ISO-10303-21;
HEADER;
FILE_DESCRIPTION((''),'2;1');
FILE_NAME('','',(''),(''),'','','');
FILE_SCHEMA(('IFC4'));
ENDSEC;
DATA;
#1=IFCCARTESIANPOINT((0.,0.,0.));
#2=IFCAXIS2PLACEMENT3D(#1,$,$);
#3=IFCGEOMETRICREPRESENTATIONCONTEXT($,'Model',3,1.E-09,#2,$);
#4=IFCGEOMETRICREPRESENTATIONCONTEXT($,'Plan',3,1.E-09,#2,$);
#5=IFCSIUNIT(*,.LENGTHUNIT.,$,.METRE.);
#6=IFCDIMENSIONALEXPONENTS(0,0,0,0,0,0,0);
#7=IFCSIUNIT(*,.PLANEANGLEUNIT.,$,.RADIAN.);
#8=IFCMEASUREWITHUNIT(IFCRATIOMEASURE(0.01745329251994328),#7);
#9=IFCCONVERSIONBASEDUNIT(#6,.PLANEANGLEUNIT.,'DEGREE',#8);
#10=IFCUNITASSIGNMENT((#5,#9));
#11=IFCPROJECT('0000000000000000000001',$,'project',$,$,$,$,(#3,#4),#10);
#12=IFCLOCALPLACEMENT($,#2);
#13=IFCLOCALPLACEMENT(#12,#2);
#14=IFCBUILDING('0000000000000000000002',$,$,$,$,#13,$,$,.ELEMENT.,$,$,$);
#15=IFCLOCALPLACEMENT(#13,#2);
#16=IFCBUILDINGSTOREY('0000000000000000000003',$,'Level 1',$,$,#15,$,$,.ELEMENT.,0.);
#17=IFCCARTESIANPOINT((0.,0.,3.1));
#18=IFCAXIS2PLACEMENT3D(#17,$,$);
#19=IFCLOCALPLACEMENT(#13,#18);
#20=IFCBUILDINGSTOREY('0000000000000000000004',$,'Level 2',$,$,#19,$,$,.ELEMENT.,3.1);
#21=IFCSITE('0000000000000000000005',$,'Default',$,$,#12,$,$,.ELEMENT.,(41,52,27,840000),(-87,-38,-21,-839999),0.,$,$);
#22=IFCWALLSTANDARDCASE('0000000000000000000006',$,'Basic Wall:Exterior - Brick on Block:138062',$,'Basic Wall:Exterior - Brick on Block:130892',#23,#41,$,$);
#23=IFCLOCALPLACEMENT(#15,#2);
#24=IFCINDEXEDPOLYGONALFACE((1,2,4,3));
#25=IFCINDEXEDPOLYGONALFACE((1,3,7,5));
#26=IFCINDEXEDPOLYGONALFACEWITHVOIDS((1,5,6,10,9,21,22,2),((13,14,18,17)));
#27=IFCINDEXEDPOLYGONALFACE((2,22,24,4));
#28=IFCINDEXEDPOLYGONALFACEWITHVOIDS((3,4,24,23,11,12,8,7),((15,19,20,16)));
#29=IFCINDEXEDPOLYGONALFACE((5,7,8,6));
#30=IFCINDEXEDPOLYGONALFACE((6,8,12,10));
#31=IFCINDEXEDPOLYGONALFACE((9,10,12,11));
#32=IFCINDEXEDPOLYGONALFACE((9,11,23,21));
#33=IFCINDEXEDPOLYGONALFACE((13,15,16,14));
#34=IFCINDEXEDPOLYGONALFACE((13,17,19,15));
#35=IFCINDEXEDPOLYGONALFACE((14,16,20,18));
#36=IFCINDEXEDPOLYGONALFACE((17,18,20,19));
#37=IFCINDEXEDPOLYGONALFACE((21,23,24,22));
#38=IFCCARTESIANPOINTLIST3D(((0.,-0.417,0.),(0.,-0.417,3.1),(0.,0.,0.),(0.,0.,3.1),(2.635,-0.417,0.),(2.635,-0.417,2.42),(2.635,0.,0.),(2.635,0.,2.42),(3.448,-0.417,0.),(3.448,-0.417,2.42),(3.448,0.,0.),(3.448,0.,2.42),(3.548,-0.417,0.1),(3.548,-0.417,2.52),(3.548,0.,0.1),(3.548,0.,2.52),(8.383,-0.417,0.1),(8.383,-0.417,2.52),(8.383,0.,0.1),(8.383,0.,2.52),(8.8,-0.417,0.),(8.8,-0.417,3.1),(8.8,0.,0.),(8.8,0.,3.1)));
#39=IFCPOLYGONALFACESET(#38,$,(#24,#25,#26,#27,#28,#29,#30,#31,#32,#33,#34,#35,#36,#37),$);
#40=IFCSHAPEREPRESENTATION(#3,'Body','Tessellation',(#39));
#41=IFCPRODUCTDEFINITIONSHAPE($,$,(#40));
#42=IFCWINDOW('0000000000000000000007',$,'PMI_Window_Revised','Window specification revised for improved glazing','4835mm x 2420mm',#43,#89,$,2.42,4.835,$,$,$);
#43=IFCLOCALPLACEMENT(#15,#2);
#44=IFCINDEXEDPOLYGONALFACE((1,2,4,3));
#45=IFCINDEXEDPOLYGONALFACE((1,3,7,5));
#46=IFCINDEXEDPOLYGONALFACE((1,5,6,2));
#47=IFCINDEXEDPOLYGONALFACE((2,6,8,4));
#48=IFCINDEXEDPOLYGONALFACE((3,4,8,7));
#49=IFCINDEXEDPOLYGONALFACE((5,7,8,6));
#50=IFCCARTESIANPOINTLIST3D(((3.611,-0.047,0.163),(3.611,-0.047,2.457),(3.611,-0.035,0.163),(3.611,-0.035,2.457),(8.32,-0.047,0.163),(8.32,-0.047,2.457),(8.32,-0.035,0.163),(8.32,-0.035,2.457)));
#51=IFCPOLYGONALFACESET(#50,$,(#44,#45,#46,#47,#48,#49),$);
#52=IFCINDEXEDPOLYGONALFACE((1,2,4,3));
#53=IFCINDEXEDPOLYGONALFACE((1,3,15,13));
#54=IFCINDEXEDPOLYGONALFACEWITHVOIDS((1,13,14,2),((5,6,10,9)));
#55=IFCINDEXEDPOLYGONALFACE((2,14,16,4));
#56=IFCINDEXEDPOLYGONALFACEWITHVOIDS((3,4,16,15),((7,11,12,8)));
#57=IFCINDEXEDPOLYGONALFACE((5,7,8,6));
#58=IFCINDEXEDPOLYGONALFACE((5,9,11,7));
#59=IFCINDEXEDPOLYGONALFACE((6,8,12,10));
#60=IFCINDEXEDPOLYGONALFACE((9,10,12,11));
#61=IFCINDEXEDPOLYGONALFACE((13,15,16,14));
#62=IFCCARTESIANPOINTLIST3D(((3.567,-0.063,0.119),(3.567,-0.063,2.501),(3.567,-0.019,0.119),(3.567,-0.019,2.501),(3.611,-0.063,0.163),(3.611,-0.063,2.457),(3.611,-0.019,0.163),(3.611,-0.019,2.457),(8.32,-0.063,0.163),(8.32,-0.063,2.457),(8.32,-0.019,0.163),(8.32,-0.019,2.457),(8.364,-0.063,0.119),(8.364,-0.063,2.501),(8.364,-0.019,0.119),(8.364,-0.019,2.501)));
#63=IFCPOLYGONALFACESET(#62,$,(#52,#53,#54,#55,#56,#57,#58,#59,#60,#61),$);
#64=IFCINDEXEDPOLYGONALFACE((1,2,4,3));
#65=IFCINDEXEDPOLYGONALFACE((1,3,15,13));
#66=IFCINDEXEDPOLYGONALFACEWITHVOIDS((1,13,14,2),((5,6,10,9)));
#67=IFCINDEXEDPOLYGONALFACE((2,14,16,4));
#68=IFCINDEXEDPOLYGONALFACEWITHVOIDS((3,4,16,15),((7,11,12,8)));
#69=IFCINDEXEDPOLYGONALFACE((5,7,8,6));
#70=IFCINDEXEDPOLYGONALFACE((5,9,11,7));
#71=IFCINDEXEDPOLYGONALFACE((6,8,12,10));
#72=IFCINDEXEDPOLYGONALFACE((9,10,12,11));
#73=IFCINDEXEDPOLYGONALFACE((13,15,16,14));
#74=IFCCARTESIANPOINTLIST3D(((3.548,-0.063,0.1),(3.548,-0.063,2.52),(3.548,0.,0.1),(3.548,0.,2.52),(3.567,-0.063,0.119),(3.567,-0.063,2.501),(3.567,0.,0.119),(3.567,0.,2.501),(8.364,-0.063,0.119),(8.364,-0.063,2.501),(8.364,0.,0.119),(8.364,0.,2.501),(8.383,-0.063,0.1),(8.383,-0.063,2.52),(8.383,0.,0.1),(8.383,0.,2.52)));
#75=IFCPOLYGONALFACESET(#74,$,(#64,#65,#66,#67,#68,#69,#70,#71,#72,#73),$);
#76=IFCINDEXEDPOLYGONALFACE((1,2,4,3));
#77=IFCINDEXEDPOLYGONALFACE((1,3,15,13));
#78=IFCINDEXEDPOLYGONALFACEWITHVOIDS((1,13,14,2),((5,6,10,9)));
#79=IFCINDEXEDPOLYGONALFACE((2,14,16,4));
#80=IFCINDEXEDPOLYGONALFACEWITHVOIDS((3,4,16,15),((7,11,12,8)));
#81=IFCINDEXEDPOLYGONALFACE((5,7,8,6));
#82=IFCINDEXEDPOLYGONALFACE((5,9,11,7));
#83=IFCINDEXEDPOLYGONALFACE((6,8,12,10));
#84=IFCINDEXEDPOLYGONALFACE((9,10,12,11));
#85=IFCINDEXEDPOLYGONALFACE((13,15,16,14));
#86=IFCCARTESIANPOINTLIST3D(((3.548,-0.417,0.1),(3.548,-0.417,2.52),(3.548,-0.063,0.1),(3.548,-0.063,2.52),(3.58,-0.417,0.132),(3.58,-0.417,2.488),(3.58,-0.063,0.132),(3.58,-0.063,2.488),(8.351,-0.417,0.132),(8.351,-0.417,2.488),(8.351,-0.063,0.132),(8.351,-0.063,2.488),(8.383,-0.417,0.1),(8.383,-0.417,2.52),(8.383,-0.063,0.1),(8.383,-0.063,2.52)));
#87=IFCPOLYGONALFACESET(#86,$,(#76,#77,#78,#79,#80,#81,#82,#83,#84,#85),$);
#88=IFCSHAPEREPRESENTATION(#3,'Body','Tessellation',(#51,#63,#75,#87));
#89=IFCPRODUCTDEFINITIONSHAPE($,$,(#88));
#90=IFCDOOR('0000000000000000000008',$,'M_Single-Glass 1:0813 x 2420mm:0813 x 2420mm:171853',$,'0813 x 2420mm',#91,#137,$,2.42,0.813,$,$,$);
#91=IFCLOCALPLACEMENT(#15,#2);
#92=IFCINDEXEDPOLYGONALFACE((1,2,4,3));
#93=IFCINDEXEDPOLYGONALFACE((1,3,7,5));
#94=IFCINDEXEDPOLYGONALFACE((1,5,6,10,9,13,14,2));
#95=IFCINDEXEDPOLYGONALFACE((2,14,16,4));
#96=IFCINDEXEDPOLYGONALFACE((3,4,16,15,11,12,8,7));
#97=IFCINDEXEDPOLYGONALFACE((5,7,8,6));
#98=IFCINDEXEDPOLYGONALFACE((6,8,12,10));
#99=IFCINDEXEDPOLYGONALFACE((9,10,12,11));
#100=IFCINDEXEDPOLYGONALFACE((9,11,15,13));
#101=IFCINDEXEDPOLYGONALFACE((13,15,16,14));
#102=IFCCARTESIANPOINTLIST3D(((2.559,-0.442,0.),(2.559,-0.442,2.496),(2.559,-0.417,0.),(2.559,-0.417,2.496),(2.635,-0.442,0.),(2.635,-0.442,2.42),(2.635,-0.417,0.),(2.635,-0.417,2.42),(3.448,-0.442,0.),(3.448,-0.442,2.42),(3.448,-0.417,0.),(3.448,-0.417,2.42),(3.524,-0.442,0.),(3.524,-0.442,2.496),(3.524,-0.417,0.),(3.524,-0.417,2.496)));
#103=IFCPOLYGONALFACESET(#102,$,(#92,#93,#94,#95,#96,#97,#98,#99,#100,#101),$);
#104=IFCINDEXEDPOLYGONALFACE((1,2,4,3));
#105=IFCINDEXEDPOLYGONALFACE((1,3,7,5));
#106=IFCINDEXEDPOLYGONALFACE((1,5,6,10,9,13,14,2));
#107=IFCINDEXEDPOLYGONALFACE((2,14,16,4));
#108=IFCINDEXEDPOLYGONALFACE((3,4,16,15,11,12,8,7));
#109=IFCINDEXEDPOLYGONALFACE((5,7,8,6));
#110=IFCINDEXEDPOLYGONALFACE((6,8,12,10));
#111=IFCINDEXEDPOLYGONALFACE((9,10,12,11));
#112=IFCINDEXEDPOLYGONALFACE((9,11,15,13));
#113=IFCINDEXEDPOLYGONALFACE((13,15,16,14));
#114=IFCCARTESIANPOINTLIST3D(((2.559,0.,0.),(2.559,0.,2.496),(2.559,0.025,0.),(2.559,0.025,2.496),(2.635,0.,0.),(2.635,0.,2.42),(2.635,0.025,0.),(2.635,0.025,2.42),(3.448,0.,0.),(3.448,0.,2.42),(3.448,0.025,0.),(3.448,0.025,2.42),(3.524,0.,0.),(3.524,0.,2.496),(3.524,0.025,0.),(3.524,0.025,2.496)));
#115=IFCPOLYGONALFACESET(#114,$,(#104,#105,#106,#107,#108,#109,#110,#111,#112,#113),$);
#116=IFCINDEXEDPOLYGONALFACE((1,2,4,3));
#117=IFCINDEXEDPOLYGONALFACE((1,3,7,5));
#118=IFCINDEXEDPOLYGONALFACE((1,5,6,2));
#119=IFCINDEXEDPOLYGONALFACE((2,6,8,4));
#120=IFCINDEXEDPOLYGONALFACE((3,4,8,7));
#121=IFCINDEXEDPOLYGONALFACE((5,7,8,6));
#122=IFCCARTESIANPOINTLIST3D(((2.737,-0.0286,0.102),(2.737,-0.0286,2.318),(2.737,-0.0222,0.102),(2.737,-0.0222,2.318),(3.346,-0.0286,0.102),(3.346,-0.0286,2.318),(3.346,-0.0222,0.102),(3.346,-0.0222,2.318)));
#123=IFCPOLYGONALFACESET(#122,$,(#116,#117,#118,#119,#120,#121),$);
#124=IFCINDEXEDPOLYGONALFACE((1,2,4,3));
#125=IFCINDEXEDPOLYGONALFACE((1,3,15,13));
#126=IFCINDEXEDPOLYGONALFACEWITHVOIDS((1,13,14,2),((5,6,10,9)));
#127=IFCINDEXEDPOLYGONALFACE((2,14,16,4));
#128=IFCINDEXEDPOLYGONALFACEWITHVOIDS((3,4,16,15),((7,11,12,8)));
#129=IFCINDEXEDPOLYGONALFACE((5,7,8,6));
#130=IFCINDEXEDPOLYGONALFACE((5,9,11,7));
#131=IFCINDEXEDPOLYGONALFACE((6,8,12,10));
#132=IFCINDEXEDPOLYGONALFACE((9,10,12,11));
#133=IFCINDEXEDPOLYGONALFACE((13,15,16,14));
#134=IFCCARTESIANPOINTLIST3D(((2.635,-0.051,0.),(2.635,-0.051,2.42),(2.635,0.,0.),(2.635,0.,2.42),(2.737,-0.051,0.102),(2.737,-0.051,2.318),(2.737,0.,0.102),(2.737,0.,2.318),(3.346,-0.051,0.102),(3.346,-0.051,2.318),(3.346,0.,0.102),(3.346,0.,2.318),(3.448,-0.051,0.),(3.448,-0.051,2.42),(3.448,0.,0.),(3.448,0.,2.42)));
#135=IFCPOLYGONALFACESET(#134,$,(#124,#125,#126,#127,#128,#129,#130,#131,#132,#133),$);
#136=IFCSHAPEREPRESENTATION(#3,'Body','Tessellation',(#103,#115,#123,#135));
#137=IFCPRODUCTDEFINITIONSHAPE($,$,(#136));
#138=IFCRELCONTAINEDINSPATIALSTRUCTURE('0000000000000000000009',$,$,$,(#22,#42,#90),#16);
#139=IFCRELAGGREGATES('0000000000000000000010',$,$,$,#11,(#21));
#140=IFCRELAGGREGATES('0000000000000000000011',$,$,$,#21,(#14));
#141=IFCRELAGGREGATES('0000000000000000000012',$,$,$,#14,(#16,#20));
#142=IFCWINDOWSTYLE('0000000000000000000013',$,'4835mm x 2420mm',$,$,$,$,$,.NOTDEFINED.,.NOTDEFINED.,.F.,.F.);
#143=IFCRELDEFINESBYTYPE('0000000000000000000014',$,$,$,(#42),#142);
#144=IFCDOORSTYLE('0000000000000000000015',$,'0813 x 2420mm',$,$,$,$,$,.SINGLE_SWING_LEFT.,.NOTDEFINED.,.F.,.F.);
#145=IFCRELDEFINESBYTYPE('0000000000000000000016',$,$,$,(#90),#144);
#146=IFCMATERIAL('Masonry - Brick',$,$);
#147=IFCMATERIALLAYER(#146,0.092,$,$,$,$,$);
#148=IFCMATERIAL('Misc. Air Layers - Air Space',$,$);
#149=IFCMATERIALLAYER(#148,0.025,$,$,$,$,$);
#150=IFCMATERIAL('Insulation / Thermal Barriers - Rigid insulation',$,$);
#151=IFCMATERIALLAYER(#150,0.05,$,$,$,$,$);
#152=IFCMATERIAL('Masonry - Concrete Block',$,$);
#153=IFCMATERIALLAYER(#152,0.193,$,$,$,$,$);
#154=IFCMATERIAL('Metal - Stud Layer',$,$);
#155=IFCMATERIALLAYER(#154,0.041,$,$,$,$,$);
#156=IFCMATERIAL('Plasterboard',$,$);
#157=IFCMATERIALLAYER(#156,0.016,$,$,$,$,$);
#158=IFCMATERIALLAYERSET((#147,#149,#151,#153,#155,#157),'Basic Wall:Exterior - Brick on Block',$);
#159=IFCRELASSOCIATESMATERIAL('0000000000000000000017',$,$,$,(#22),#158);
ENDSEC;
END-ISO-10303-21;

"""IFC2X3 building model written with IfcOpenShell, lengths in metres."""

from ifc_helpers import new_model, entity, si_unit, converted_unit, frame, frame_2d, origin, origin_2d_with_axis, place, context, project, spatial, polyline, rectangle, outline, extrude, source, transform, mapped, material, layer, layer_set, layer_usage, type_object, type_shapes, element, fill, save


model = new_model("IFC2X3")

# Units and contexts
model_context = context("Model", 3, precision=1e-09, world=origin())
plan_context = context("Plan", 3, precision=1e-09, world=origin())
ifc_project = project(units=[si_unit("LENGTHUNIT", "METRE"), converted_unit("PLANEANGLEUNIT", "DEGREE", entity("IfcRatioMeasure", 0.01745329251994328), si_unit("PLANEANGLEUNIT", "RADIAN"), dimensions=[0, 0, 0, 0, 0, 0, 0])], contexts=[model_context, plan_context])

# Site, building, storey
site_placement = place(None, origin())
site = spatial("IfcSite", under=ifc_project, at=site_placement, Name="Default", CompositionType="ELEMENT", RefLatitude=(41, 52, 27, 840000), RefLongitude=(-87, -38, -21, -839999), RefElevation=0.0)
building_placement = place(site_placement, origin())
building = spatial("IfcBuilding", under=site, at=building_placement, CompositionType="ELEMENT")
storey_1_placement = place(building_placement, origin())
storey_1 = spatial("IfcBuildingStorey", under=building, at=storey_1_placement, Name="Level 1", CompositionType="ELEMENT", Elevation=0.0)

# Wall, openings, window, door
ifc_material_1 = material(Name="Masonry - Brick")
ifc_layer_1 = layer(ifc_material_1, 0.092)
ifc_material_2 = material(Name="Misc. Air Layers - Air Space")
ifc_layer_2 = layer(ifc_material_2, 0.025)
ifc_material_3 = material(Name="Insulation / Thermal Barriers - Rigid insulation")
ifc_layer_3 = layer(ifc_material_3, 0.05)
ifc_material_4 = material(Name="Masonry - Concrete Block")
ifc_layer_4 = layer(ifc_material_4, 0.193)
ifc_material_5 = material(Name="Metal - Stud Layer")
ifc_layer_5 = layer(ifc_material_5, 0.041)
ifc_material_6 = material(Name="Plasterboard")
ifc_layer_6 = layer(ifc_material_6, 0.016)
ifc_layer_set_1 = layer_set([ifc_layer_1, ifc_layer_2, ifc_layer_3, ifc_layer_4, ifc_layer_5, ifc_layer_6], Name="Basic Wall:Exterior - Brick on Block")
ifc_layer_usage_1 = layer_usage(ifc_layer_set_1, "AXIS2", "NEGATIVE", 0.2085)
wall_1_placement = place(storey_1_placement, frame((0.0, -0.2085, 0.0)))
wall_1 = element("IfcWallStandardCase", 1, at=wall_1_placement, inside=storey_1, material=ifc_layer_usage_1, Name="Basic Wall:Exterior - Brick on Block:138062", ObjectType="Basic Wall:Exterior - Brick on Block:130892", context=model_context, shape_type="SweptSolid", body=[
    extrude(rectangle(XDim=8.8, YDim=0.417, at=frame_2d((4.4, 0.0), x_axis=(-1.0, 0.0))), origin(), (0.0, 0.0, 1.0), 3.1),
])
opening_1_placement = place(wall_1_placement, frame((3.548, -0.2085, 0.1)))
opening_1 = element("IfcOpeningElement", 2, at=opening_1_placement, cuts=wall_1, ObjectType="Opening", context=model_context, shape_type="SweptSolid", body=[
    extrude(rectangle(XDim=2.42, YDim=4.835, at=frame_2d((1.21, 2.4175), x_axis=(1.0, 0.0))), frame((0.0, 0.0, 0.0), z_axis=(0.0, 1.0, 0.0), x_axis=(0.0, 0.0, 1.0)), (0.0, 0.0, 1.0), 0.417),
])
opening_2_placement = place(wall_1_placement, frame((2.635, -0.2085, 0.0)))
opening_2 = element("IfcOpeningElement", 3, at=opening_2_placement, cuts=wall_1, ObjectType="Opening", context=model_context, shape_type="SweptSolid", body=[
    extrude(rectangle(XDim=0.813, YDim=2.42, at=frame_2d((1.21, 0.4065), x_axis=(0.0, -1.0))), frame((0.0, 0.0, 0.0), z_axis=(0.0, 1.0, 0.0), x_axis=(0.0, 0.0, 1.0)), (0.0, 0.0, 1.0), 0.417),
])
window_style_1 = type_object("IfcWindowStyle", Name="4835mm x 2420mm", ConstructionType="NOTDEFINED", OperationType="NOTDEFINED", ParameterTakesPrecedence=False, Sizeable=False)
shared_shape_1 = source(origin(), model_context, "Body", "SweptSolid", [
    extrude(rectangle(XDim=0.012, YDim=4.709, at=origin_2d_with_axis()), frame((2.4175, 0.376, 0.063), z_axis=(0.0, 0.0, 1.0), x_axis=(0.0, -1.0, 0.0)), (0.0, 0.0, 1.0), 2.294),
    extrude(outline(polyline([(-2.3985, -1.191), (2.3985, -1.191), (2.3985, 1.191), (-2.3985, 1.191), (-2.3985, -1.191)]), holes=[polyline([(-2.3545, -1.147), (-2.3545, 1.147), (2.3545, 1.147), (2.3545, -1.147), (-2.3545, -1.147)])]), frame((2.4175, 0.354, 1.21), z_axis=(0.0, 1.0, 0.0), x_axis=(1.0, 0.0, 0.0)), (0.0, 0.0, 1.0), 0.044),
    extrude(outline(polyline([(-2.4175, -1.21), (2.4175, -1.21), (2.4175, 1.21), (-2.4175, 1.21), (-2.4175, -1.21)]), holes=[polyline([(-2.3985, -1.191), (-2.3985, 1.191), (2.3985, 1.191), (2.3985, -1.191), (-2.3985, -1.191)])]), frame((2.4175, 0.354, 1.21), z_axis=(0.0, 1.0, 0.0), x_axis=(1.0, 0.0, 0.0)), (0.0, 0.0, 1.0), 0.063),
    extrude(outline(polyline([(-2.4175, -1.21), (2.4175, -1.21), (2.4175, 1.21), (-2.4175, 1.21), (-2.4175, -1.21)]), holes=[polyline([(-2.3855, -1.178), (-2.3855, 1.178), (2.3855, 1.178), (2.3855, -1.178), (-2.3855, -1.178)])]), frame((2.4175, 0.0, 1.21), z_axis=(0.0, 1.0, 0.0), x_axis=(1.0, 0.0, 0.0)), (0.0, 0.0, 1.0), 0.354),
])
type_shapes(window_style_1, [shared_shape_1])
window_1_placement = place(opening_1_placement, origin())
window_1 = element("IfcWindow", 4, at=window_1_placement, inside=storey_1, type_object=window_style_1, Name="PMI_Window_Revised", Description="Window specification revised for improved glazing", ObjectType="4835mm x 2420mm", OverallHeight=2.42, OverallWidth=4.835, context=model_context, shape_type="MappedRepresentation", body=[
    mapped(shared_shape_1, transform((0.0, 0.0, 0.0), scale=1.0)),
])
fill(opening_1, window_1)
door_style_1 = type_object("IfcDoorStyle", Name="0813 x 2420mm", ConstructionType="NOTDEFINED", OperationType="SINGLE_SWING_LEFT", ParameterTakesPrecedence=False, Sizeable=False)
shared_shape_2 = source(origin(), model_context, "Body", "SweptSolid", [
    extrude(outline(polyline([(-0.4065, -1.191), (-0.4065, 1.229), (-0.4825, 1.229), (-0.4825, -1.267), (0.4825, -1.267), (0.4825, 1.229), (0.4065, 1.229), (0.4065, -1.191), (-0.4065, -1.191)])), frame((0.4065, 0.0, 1.229), z_axis=(0.0, 1.0, 0.0), x_axis=(1.0, 0.0, 0.0)), (0.0, 0.0, -1.0), 0.025),
    extrude(outline(polyline([(-0.4065, -1.191), (-0.4065, 1.229), (-0.4825, 1.229), (-0.4825, -1.267), (0.4825, -1.267), (0.4825, 1.229), (0.4065, 1.229), (0.4065, -1.191), (-0.4065, -1.191)])), frame((0.4065, 0.442, 1.229), z_axis=(0.0, 1.0, 0.0), x_axis=(1.0, 0.0, 0.0)), (0.0, 0.0, -1.0), 0.025),
    extrude(rectangle(XDim=0.609, YDim=0.0064, at=origin_2d_with_axis()), frame((0.4065, 0.3916, 0.102)), (0.0, 0.0, 1.0), 2.216),
    extrude(outline(polyline([(-1.21, -0.4065), (1.21, -0.4065), (1.21, 0.4065), (-1.21, 0.4065), (-1.21, -0.4065)]), holes=[polyline([(-1.108, 0.3045), (1.108, 0.3045), (1.108, -0.3045), (-1.108, -0.3045), (-1.108, 0.3045)])]), frame((0.4065, 0.417, 1.21), z_axis=(0.0, -1.0, 0.0), x_axis=(0.0, 0.0, -1.0)), (0.0, 0.0, 1.0), 0.051),
])
type_shapes(door_style_1, [shared_shape_2])
door_1_placement = place(opening_2_placement, origin())
door_1 = element("IfcDoor", 5, at=door_1_placement, inside=storey_1, type_object=door_style_1, Name="M_Single-Glass 1:0813 x 2420mm:0813 x 2420mm:171853", ObjectType="0813 x 2420mm", OverallHeight=2.42, OverallWidth=0.813, context=model_context, shape_type="MappedRepresentation", body=[
    mapped(shared_shape_2, transform((0.0, 0.0, 0.0), scale=1.0)),
])
fill(opening_2, door_1)

# Shared definitions
storey_2_placement = place(building_placement, frame((0.0, 0.0, 3.1)))
storey_2 = spatial("IfcBuildingStorey", under=building, at=storey_2_placement, Name="Level 2", CompositionType="ELEMENT", Elevation=3.1)

save(model, "model.ifc")
